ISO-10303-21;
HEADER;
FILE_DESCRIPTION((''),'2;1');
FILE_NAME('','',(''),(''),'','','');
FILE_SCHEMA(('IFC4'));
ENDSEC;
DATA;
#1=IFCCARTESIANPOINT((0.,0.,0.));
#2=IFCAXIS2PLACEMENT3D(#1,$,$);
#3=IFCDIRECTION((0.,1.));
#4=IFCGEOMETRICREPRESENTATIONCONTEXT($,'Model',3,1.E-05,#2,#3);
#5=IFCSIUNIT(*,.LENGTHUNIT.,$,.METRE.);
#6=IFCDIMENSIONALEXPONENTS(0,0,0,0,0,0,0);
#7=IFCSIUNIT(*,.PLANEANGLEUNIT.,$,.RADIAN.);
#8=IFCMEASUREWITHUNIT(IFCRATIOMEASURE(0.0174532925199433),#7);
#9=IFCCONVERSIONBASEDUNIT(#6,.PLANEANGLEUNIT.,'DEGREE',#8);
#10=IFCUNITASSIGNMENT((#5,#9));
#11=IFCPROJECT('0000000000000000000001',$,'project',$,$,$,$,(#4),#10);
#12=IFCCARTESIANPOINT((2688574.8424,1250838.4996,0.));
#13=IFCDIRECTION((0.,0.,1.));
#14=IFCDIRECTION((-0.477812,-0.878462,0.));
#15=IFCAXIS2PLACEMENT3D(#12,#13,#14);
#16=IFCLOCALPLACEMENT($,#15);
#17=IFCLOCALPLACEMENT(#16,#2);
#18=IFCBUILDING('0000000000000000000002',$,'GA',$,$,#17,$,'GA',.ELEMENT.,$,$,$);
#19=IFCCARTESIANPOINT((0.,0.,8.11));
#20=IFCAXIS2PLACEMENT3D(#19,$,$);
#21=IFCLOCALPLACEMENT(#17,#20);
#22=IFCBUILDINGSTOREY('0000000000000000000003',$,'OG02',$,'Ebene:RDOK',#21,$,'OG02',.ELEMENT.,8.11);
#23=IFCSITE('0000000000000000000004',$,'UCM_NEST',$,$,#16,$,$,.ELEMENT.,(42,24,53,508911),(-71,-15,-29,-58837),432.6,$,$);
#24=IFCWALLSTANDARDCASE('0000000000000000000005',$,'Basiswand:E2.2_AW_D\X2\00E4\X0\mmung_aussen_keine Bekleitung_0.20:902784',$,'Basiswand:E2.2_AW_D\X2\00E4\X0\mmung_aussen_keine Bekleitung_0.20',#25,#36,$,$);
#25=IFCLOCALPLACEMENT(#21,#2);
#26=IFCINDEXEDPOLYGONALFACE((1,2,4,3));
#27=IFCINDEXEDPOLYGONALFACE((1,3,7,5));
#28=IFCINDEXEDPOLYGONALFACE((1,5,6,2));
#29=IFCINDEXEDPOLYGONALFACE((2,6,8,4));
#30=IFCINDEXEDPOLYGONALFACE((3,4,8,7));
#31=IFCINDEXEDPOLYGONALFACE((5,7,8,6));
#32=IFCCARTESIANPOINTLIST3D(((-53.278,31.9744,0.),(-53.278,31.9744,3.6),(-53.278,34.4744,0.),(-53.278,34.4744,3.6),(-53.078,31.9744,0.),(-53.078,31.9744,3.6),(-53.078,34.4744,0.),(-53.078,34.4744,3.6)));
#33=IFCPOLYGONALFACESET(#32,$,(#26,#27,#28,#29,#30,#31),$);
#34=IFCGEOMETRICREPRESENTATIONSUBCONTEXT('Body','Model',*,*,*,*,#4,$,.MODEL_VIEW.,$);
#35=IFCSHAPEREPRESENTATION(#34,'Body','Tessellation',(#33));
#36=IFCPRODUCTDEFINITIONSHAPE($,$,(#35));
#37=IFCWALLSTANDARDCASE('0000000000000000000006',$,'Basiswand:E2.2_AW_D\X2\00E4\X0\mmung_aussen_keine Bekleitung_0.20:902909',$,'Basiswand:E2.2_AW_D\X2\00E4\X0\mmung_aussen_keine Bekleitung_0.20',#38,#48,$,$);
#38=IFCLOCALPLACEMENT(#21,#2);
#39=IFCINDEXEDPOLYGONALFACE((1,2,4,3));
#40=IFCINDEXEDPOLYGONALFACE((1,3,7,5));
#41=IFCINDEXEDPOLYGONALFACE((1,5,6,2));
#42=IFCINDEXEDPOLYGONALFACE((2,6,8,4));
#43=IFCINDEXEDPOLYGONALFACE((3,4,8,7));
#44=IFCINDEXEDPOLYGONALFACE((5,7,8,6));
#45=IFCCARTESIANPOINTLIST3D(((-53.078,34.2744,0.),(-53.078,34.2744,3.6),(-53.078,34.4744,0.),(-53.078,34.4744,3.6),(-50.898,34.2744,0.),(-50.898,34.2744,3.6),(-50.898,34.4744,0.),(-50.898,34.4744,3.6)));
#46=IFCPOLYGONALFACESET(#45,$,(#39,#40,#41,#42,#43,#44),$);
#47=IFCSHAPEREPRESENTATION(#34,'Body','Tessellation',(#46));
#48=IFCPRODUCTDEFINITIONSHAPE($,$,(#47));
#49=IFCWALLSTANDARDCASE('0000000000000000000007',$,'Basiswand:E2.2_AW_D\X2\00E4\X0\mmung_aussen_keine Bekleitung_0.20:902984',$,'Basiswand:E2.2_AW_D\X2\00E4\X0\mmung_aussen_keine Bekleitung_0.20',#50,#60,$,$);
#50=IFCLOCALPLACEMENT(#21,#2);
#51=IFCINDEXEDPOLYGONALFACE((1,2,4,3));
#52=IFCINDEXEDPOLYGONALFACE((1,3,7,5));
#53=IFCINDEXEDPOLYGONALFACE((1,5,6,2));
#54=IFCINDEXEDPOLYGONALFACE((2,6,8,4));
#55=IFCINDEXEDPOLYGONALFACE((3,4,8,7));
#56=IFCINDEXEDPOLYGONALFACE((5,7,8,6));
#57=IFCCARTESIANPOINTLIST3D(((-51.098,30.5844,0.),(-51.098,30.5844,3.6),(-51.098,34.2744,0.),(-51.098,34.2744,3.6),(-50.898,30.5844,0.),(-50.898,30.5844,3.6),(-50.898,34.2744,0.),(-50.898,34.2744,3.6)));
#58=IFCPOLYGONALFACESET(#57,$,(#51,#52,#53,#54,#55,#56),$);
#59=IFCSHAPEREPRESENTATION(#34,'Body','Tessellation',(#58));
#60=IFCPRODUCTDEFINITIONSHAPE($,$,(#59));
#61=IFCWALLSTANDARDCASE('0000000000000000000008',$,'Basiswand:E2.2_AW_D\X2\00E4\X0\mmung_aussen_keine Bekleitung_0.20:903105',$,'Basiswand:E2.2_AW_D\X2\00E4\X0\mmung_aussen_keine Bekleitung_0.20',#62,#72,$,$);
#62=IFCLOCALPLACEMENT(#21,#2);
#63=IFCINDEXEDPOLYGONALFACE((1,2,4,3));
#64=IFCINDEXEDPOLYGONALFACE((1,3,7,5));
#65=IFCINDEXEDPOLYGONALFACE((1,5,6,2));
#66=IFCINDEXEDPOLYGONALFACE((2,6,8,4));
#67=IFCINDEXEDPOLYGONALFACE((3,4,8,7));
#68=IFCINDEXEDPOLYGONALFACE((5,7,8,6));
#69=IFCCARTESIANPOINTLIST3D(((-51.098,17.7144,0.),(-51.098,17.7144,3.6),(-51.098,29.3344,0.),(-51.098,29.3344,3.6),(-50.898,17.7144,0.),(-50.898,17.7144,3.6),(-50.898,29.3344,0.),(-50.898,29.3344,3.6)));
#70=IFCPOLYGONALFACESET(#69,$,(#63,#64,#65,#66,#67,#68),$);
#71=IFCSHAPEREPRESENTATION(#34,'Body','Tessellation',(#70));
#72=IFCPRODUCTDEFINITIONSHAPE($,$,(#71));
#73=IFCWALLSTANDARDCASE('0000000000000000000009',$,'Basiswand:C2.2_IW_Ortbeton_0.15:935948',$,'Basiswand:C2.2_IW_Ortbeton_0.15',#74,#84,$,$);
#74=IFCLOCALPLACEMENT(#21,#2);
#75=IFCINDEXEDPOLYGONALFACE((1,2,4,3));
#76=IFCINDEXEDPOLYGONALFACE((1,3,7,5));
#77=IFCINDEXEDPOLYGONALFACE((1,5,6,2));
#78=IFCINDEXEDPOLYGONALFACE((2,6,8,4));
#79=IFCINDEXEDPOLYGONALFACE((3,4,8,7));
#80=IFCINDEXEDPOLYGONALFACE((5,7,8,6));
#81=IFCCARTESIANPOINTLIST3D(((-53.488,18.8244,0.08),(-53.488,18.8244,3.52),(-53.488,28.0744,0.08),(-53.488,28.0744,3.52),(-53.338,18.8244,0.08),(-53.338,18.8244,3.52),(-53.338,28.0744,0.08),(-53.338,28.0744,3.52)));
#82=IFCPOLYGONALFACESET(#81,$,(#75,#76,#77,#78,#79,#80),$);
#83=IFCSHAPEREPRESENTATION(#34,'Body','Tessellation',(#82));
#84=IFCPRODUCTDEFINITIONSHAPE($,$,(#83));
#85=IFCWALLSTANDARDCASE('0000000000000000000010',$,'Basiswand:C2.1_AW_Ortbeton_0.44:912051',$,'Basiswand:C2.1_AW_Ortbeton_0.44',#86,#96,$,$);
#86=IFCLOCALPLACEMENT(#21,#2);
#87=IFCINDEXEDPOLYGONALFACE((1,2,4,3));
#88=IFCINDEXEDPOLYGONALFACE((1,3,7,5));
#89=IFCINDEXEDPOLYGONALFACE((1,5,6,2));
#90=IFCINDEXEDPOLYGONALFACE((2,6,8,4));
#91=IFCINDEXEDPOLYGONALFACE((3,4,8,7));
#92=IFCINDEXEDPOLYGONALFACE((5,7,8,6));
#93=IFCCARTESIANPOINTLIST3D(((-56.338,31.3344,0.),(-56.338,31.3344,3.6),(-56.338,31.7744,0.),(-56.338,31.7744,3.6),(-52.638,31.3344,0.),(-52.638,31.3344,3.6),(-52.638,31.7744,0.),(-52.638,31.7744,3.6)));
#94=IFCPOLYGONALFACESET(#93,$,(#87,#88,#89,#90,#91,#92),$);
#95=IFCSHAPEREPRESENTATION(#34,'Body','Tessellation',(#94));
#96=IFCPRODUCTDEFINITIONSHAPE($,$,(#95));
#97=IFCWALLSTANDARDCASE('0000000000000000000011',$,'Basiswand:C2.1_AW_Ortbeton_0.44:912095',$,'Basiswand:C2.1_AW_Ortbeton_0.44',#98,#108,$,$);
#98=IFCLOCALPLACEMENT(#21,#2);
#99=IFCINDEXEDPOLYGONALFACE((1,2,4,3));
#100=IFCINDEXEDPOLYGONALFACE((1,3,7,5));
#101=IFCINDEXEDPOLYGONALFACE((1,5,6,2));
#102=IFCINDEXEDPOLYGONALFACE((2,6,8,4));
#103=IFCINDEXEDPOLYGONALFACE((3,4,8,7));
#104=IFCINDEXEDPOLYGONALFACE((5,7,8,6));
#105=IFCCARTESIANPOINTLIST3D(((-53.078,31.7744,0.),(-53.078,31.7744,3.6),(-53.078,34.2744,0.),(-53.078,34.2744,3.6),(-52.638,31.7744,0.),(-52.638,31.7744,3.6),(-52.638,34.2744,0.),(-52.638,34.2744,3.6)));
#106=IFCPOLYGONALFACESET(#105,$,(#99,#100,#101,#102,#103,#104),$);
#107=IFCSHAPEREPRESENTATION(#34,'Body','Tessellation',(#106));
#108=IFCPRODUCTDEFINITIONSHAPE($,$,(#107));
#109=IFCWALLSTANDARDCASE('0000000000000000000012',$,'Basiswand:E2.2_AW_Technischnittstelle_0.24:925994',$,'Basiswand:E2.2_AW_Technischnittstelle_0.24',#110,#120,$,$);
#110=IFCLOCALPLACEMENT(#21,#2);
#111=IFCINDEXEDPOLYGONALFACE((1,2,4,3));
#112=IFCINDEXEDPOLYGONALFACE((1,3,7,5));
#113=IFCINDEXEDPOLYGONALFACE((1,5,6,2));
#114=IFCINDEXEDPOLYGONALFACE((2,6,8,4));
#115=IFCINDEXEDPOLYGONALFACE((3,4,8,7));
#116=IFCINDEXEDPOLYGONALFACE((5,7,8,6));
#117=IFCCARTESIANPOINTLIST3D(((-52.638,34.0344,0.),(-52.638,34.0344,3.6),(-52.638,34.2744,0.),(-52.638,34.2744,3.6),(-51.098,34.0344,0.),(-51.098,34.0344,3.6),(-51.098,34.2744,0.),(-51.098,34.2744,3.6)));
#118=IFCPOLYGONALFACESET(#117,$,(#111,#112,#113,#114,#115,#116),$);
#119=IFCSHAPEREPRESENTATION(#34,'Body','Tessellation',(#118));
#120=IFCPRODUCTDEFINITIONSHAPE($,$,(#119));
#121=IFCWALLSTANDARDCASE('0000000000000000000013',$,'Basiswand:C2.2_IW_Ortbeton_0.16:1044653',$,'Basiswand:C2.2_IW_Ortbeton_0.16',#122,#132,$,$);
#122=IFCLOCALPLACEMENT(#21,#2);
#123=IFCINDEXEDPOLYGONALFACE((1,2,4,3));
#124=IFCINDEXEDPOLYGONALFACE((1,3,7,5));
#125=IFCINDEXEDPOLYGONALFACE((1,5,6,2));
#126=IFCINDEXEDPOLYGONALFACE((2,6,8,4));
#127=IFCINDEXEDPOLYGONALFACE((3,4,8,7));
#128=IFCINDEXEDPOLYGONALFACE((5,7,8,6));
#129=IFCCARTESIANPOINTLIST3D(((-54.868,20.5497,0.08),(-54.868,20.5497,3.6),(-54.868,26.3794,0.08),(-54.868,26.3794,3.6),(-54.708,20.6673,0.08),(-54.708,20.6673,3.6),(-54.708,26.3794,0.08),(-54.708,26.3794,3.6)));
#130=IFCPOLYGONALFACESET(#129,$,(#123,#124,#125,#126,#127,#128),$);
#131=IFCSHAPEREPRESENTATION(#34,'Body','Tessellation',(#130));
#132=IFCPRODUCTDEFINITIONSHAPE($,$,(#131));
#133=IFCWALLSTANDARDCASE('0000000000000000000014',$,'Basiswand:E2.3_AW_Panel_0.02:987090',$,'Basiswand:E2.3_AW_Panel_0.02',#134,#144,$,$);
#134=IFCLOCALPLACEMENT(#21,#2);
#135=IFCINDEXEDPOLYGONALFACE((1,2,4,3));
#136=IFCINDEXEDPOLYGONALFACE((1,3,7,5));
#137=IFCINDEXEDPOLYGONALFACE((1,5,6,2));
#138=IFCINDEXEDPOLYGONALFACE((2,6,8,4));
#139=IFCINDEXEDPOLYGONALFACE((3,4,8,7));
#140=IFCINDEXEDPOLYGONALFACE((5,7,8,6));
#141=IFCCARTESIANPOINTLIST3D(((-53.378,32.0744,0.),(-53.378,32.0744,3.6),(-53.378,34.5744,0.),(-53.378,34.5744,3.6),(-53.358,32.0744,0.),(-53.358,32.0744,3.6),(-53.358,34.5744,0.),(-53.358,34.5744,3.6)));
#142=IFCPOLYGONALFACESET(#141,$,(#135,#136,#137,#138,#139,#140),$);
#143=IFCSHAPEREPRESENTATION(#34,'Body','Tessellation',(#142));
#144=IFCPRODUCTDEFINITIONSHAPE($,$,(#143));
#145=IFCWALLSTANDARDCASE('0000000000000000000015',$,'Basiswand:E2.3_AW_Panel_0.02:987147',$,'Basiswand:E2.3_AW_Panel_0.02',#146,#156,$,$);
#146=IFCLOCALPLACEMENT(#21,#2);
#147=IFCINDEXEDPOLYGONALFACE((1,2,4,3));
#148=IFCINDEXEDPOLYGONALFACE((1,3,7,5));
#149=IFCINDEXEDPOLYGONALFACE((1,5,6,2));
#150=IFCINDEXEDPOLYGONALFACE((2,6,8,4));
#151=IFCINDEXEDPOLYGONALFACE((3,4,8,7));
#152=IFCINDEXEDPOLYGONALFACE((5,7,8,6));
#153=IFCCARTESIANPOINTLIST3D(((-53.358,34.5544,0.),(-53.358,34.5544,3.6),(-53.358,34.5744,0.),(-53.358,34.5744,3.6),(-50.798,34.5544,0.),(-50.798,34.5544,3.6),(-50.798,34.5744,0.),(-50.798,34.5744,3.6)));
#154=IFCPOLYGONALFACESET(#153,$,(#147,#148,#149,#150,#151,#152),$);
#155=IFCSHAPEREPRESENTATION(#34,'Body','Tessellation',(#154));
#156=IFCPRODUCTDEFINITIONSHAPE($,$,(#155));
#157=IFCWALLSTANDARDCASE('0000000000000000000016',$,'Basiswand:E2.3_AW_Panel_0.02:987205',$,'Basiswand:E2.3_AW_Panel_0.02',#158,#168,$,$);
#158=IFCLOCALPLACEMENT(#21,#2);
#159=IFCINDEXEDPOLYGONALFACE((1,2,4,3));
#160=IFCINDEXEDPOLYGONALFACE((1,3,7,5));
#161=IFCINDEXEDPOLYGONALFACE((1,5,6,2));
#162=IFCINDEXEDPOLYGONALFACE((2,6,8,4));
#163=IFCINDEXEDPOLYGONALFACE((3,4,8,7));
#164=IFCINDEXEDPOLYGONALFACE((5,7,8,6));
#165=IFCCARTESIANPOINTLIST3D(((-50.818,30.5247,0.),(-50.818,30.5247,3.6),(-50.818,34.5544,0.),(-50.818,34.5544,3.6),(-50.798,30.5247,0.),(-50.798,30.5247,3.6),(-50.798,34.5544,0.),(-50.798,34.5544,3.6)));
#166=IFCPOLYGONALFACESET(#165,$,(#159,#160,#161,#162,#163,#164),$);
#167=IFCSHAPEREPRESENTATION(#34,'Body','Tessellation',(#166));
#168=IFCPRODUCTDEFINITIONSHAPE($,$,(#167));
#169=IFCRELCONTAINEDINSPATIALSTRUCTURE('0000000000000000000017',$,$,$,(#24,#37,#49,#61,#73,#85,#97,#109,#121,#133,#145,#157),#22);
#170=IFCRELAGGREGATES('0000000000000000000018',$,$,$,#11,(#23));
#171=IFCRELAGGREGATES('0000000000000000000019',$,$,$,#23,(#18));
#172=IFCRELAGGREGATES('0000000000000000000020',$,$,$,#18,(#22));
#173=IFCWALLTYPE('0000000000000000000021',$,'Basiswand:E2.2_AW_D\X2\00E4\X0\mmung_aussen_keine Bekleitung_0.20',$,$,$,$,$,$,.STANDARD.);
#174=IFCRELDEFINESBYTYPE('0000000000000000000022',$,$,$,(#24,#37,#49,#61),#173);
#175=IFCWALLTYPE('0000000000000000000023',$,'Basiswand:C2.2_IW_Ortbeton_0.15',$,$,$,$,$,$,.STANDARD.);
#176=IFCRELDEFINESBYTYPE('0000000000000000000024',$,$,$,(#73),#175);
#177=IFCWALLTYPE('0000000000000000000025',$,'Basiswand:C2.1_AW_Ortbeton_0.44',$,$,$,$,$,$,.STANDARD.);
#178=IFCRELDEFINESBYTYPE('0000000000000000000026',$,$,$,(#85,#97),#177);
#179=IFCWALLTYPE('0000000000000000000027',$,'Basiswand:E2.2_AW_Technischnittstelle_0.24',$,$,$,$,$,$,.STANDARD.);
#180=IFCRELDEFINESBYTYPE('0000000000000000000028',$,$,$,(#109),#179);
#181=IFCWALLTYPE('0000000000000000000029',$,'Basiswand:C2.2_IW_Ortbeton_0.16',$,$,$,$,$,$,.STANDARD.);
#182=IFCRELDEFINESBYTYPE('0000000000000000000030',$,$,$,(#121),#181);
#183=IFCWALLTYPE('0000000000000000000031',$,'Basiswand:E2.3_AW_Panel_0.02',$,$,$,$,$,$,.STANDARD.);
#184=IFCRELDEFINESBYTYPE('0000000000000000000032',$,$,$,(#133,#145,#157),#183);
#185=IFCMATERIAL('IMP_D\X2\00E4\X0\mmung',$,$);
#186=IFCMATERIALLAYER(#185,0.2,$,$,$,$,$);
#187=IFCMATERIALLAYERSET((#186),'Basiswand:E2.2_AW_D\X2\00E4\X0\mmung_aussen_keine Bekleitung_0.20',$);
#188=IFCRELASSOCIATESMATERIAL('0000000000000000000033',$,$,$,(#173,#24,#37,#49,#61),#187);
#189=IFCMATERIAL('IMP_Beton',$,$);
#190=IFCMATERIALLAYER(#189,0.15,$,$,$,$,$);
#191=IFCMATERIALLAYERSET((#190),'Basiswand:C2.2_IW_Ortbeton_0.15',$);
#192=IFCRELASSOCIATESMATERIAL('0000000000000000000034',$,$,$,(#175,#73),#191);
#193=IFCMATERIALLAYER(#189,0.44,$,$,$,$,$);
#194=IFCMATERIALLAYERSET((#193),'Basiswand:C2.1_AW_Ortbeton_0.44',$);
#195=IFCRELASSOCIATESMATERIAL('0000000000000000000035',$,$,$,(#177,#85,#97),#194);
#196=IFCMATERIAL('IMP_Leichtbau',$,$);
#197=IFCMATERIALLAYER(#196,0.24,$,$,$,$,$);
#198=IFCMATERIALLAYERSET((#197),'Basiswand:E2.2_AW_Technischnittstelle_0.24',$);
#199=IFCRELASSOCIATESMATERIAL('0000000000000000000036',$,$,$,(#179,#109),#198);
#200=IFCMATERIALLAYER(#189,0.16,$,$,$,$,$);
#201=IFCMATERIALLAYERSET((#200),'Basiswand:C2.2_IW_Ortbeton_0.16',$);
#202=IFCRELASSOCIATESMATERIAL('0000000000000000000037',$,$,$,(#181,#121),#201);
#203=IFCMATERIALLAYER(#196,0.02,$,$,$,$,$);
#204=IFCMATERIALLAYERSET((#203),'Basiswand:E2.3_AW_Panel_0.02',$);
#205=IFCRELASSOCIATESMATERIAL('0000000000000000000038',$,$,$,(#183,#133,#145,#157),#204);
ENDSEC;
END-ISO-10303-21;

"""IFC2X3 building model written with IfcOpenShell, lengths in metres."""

from ifc_helpers import new_model, entity, si_unit, converted_unit, direction, frame, frame_2d, origin, place, context, subcontext, project, spatial, polyline, rectangle, outline, extrude, clip, bounded_halfspace, material, layer, layer_set, layer_usage, type_object, element, save


model = new_model("IFC2X3")

# Units and contexts
model_context = context("Model", 3, precision=1e-05, world=origin(), true_north=direction((0.0, 1.0)))
body_context = subcontext(model_context, "Body", "Model", "MODEL_VIEW")
ifc_project = project(units=[si_unit("LENGTHUNIT", "METRE"), converted_unit("PLANEANGLEUNIT", "DEGREE", entity("IfcRatioMeasure", 0.0174532925199433), si_unit("PLANEANGLEUNIT", "RADIAN"), dimensions=[0, 0, 0, 0, 0, 0, 0])], contexts=[model_context])

# Site, building, storey
site_placement = place(None, frame((2688574.8424, 1250838.4996, 0.0), z_axis=(0.0, 0.0, 1.0), x_axis=(-0.477812, -0.878462, 0.0)))
site = spatial("IfcSite", under=ifc_project, at=site_placement, Name="UCM_NEST", CompositionType="ELEMENT", RefLatitude=(42, 24, 53, 508911), RefLongitude=(-71, -15, -29, -58837), RefElevation=432.6)
building_placement = place(site_placement, origin())
building = spatial("IfcBuilding", under=site, at=building_placement, Name="GA", LongName="GA", CompositionType="ELEMENT")
storey_placement = place(building_placement, frame((0.0, 0.0, 8.11)))
storey = spatial("IfcBuildingStorey", under=building, at=storey_placement, Name="OG02", ObjectType="Ebene:RDOK", LongName="OG02", CompositionType="ELEMENT", Elevation=8.11)

# Walls
ifc_material_1 = material(Name="IMP_Dämmung")
ifc_layer_1 = layer(ifc_material_1, 0.2)
ifc_layer_set_1 = layer_set([ifc_layer_1], Name="Basiswand:E2.2_AW_Dämmung_aussen_keine Bekleitung_0.20")
ifc_layer_usage_1 = layer_usage(ifc_layer_set_1, "AXIS2", "NEGATIVE", 0.1)
wall_type_1 = type_object("IfcWallType", Name="Basiswand:E2.2_AW_Dämmung_aussen_keine Bekleitung_0.20", PredefinedType="STANDARD", material=ifc_layer_set_1)
wall_1_placement = place(storey_placement, frame((-53.178, 31.9744, 0.0), z_axis=(0.0, 0.0, 1.0), x_axis=(0.0, 1.0, 0.0)))
element("IfcWallStandardCase", 1, at=wall_1_placement, inside=storey, type_object=wall_type_1, material=ifc_layer_usage_1, Name="Basiswand:E2.2_AW_Dämmung_aussen_keine Bekleitung_0.20:902784", ObjectType="Basiswand:E2.2_AW_Dämmung_aussen_keine Bekleitung_0.20", context=body_context, shape_type="SweptSolid", body=[
    extrude(rectangle(XDim=2.5, YDim=0.2, at=frame_2d((1.25, 0.0), x_axis=(-1.0, 0.0))), origin(), (0.0, 0.0, 1.0), 3.6),
])
ifc_layer_usage_2 = layer_usage(ifc_layer_set_1, "AXIS2", "NEGATIVE", 0.1)
wall_2_placement = place(storey_placement, frame((-53.078, 34.3744, 0.0)))
element("IfcWallStandardCase", 2, at=wall_2_placement, inside=storey, type_object=wall_type_1, material=ifc_layer_usage_2, Name="Basiswand:E2.2_AW_Dämmung_aussen_keine Bekleitung_0.20:902909", ObjectType="Basiswand:E2.2_AW_Dämmung_aussen_keine Bekleitung_0.20", context=body_context, shape_type="SweptSolid", body=[
    extrude(rectangle(XDim=2.18, YDim=0.2, at=frame_2d((1.09, 0.0), x_axis=(-1.0, 0.0))), origin(), (0.0, 0.0, 1.0), 3.6),
])
ifc_layer_usage_3 = layer_usage(ifc_layer_set_1, "AXIS2", "NEGATIVE", 0.1)
wall_3_placement = place(storey_placement, frame((-50.998, 34.2744, 0.0), z_axis=(0.0, 0.0, 1.0), x_axis=(0.0, -1.0, 0.0)))
element("IfcWallStandardCase", 3, at=wall_3_placement, inside=storey, type_object=wall_type_1, material=ifc_layer_usage_3, Name="Basiswand:E2.2_AW_Dämmung_aussen_keine Bekleitung_0.20:902984", ObjectType="Basiswand:E2.2_AW_Dämmung_aussen_keine Bekleitung_0.20", context=body_context, shape_type="SweptSolid", body=[
    extrude(rectangle(XDim=3.69, YDim=0.2, at=frame_2d((1.845, 0.0), x_axis=(-1.0, 0.0))), origin(), (0.0, 0.0, 1.0), 3.6),
])
ifc_layer_usage_4 = layer_usage(ifc_layer_set_1, "AXIS2", "NEGATIVE", 0.1)
wall_4_placement = place(storey_placement, frame((-50.998, 29.3344, 0.0), z_axis=(0.0, 0.0, 1.0), x_axis=(0.0, -1.0, 0.0)))
element("IfcWallStandardCase", 4, at=wall_4_placement, inside=storey, type_object=wall_type_1, material=ifc_layer_usage_4, Name="Basiswand:E2.2_AW_Dämmung_aussen_keine Bekleitung_0.20:903105", ObjectType="Basiswand:E2.2_AW_Dämmung_aussen_keine Bekleitung_0.20", context=body_context, shape_type="SweptSolid", body=[
    extrude(rectangle(XDim=11.62, YDim=0.2, at=frame_2d((5.81, 0.0), x_axis=(-1.0, 0.0))), origin(), (0.0, 0.0, 1.0), 3.6),
])

# Shared definitions
ifc_material_2 = material(Name="IMP_Beton")
ifc_layer_2 = layer(ifc_material_2, 0.15)
ifc_layer_set_2 = layer_set([ifc_layer_2], Name="Basiswand:C2.2_IW_Ortbeton_0.15")
wall_type_2 = type_object("IfcWallType", Name="Basiswand:C2.2_IW_Ortbeton_0.15", PredefinedType="STANDARD", material=ifc_layer_set_2)

# Walls
ifc_layer_usage_5 = layer_usage(ifc_layer_set_2, "AXIS2", "NEGATIVE", 0.075)
wall_5_placement = place(storey_placement, frame((-53.413, 28.0744, 0.08), z_axis=(0.0, 0.0, 1.0), x_axis=(0.0, -1.0, 0.0)))
element("IfcWallStandardCase", 5, at=wall_5_placement, inside=storey, type_object=wall_type_2, material=ifc_layer_usage_5, Name="Basiswand:C2.2_IW_Ortbeton_0.15:935948", ObjectType="Basiswand:C2.2_IW_Ortbeton_0.15", context=body_context, shape_type="Clipping", body=[
    clip(clip(extrude(rectangle(XDim=9.25, YDim=0.15, at=frame_2d((4.625, 0.0), x_axis=(-1.0, 0.0))), origin(), (0.0, 0.0, 1.0), 3.44), bounded_halfspace(frame((0.0, -0.075, 3.44), z_axis=(0.0, 0.0, -1.0), x_axis=(0.0, -1.0, 0.0)), True, frame((0.0, -0.075, 3.44), z_axis=(0.0, 0.0, -1.0), x_axis=(0.0, -1.0, 0.0)), polyline([(0.0, 0.0), (-0.15, 0.0), (-0.15, -9.1), (-0.15, -9.25), (0.0, -9.25), (0.0, 0.0)]))), bounded_halfspace(frame((9.25, -0.075, 0.0), z_axis=(0.0, 0.0, 1.0), x_axis=(0.0, -1.0, 0.0)), True, frame((9.25, -0.075, 0.0), z_axis=(0.0, 0.0, 1.0), x_axis=(0.0, -1.0, 0.0)), polyline([(0.0, 0.0), (-0.15, 0.0), (-0.15, -0.15), (-0.15, -9.25), (0.0, -9.25), (0.0, 0.0)]))),
])
ifc_layer_3 = layer(ifc_material_2, 0.44)
ifc_layer_set_3 = layer_set([ifc_layer_3], Name="Basiswand:C2.1_AW_Ortbeton_0.44")
ifc_layer_usage_6 = layer_usage(ifc_layer_set_3, "AXIS2", "NEGATIVE", 0.22)
wall_type_3 = type_object("IfcWallType", Name="Basiswand:C2.1_AW_Ortbeton_0.44", PredefinedType="STANDARD", material=ifc_layer_set_3)
wall_6_placement = place(storey_placement, frame((-56.338, 31.5544, 0.0)))
element("IfcWallStandardCase", 6, at=wall_6_placement, inside=storey, type_object=wall_type_3, material=ifc_layer_usage_6, Name="Basiswand:C2.1_AW_Ortbeton_0.44:912051", ObjectType="Basiswand:C2.1_AW_Ortbeton_0.44", context=body_context, shape_type="SweptSolid", body=[
    extrude(rectangle(XDim=3.7, YDim=0.44, at=frame_2d((1.85, 0.0), x_axis=(-1.0, 0.0))), origin(), (0.0, 0.0, 1.0), 3.6),
])
ifc_layer_usage_7 = layer_usage(ifc_layer_set_3, "AXIS2", "NEGATIVE", 0.22)
wall_7_placement = place(storey_placement, frame((-52.858, 31.7744, 0.0), z_axis=(0.0, 0.0, 1.0), x_axis=(0.0, 1.0, 0.0)))
element("IfcWallStandardCase", 7, at=wall_7_placement, inside=storey, type_object=wall_type_3, material=ifc_layer_usage_7, Name="Basiswand:C2.1_AW_Ortbeton_0.44:912095", ObjectType="Basiswand:C2.1_AW_Ortbeton_0.44", context=body_context, shape_type="SweptSolid", body=[
    extrude(rectangle(XDim=2.5, YDim=0.44, at=frame_2d((1.25, 0.0), x_axis=(-1.0, 0.0))), origin(), (0.0, 0.0, 1.0), 3.6),
])

# Wall
ifc_material_3 = material(Name="IMP_Leichtbau")
ifc_layer_4 = layer(ifc_material_3, 0.24)
ifc_layer_set_4 = layer_set([ifc_layer_4], Name="Basiswand:E2.2_AW_Technischnittstelle_0.24")
ifc_layer_usage_8 = layer_usage(ifc_layer_set_4, "AXIS2", "NEGATIVE", 0.12)
wall_type_4 = type_object("IfcWallType", Name="Basiswand:E2.2_AW_Technischnittstelle_0.24", PredefinedType="STANDARD", material=ifc_layer_set_4)
wall_8_placement = place(storey_placement, frame((-52.638, 34.1544, 0.0)))
element("IfcWallStandardCase", 8, at=wall_8_placement, inside=storey, type_object=wall_type_4, material=ifc_layer_usage_8, Name="Basiswand:E2.2_AW_Technischnittstelle_0.24:925994", ObjectType="Basiswand:E2.2_AW_Technischnittstelle_0.24", context=body_context, shape_type="SweptSolid", body=[
    extrude(rectangle(XDim=1.54, YDim=0.24, at=frame_2d((0.77, 0.0), x_axis=(-1.0, 0.0))), origin(), (0.0, 0.0, 1.0), 3.6),
])

# Walls
ifc_layer_5 = layer(ifc_material_2, 0.16)
ifc_layer_set_5 = layer_set([ifc_layer_5], Name="Basiswand:C2.2_IW_Ortbeton_0.16")
ifc_layer_usage_9 = layer_usage(ifc_layer_set_5, "AXIS2", "NEGATIVE", 0.08)
wall_type_5 = type_object("IfcWallType", Name="Basiswand:C2.2_IW_Ortbeton_0.16", PredefinedType="STANDARD", material=ifc_layer_set_5)
wall_9_placement = place(storey_placement, frame((-54.788, 26.3794, 0.08), z_axis=(0.0, 0.0, 1.0), x_axis=(0.0, -1.0, 0.0)))
element("IfcWallStandardCase", 9, at=wall_9_placement, inside=storey, type_object=wall_type_5, material=ifc_layer_usage_9, Name="Basiswand:C2.2_IW_Ortbeton_0.16:1044653", ObjectType="Basiswand:C2.2_IW_Ortbeton_0.16", context=body_context, shape_type="Clipping", body=[
    clip(extrude(outline(polyline([(0.0, -0.08), (5.6311, -0.08), (5.8297, -0.08), (5.7121, 0.08), (0.0, 0.08), (0.0, -0.08)])), origin(), (0.0, 0.0, 1.0), 3.52), bounded_halfspace(frame((5.8297, -0.08, 0.0), z_axis=(0.0, 0.0, 1.0), x_axis=(0.0, -1.0, 0.0)), True, frame((5.8297, -0.08, 0.0), z_axis=(0.0, 0.0, 1.0), x_axis=(0.0, -1.0, 0.0)), polyline([(0.0, 0.0), (-0.16, -0.1176), (-0.16, -5.7247), (0.0, -5.7247), (0.0, 0.0)]))),
])
ifc_layer_6 = layer(ifc_material_3, 0.02)
ifc_layer_set_6 = layer_set([ifc_layer_6], Name="Basiswand:E2.3_AW_Panel_0.02")
ifc_layer_usage_10 = layer_usage(ifc_layer_set_6, "AXIS2", "NEGATIVE", 0.01)
wall_type_6 = type_object("IfcWallType", Name="Basiswand:E2.3_AW_Panel_0.02", PredefinedType="STANDARD", material=ifc_layer_set_6)
wall_10_placement = place(storey_placement, frame((-53.368, 32.0744, 0.0), z_axis=(0.0, 0.0, 1.0), x_axis=(0.0, 1.0, 0.0)))
element("IfcWallStandardCase", 10, at=wall_10_placement, inside=storey, type_object=wall_type_6, material=ifc_layer_usage_10, Name="Basiswand:E2.3_AW_Panel_0.02:987090", ObjectType="Basiswand:E2.3_AW_Panel_0.02", context=body_context, shape_type="SweptSolid", body=[
    extrude(rectangle(XDim=2.5, YDim=0.02, at=frame_2d((1.25, 0.0), x_axis=(-1.0, 0.0))), origin(), (0.0, 0.0, 1.0), 3.6),
])
ifc_layer_usage_11 = layer_usage(ifc_layer_set_6, "AXIS2", "NEGATIVE", 0.01)
wall_11_placement = place(storey_placement, frame((-53.358, 34.5644, 0.0)))
element("IfcWallStandardCase", 11, at=wall_11_placement, inside=storey, type_object=wall_type_6, material=ifc_layer_usage_11, Name="Basiswand:E2.3_AW_Panel_0.02:987147", ObjectType="Basiswand:E2.3_AW_Panel_0.02", context=body_context, shape_type="SweptSolid", body=[
    extrude(rectangle(XDim=2.56, YDim=0.02, at=frame_2d((1.28, 0.0), x_axis=(-1.0, 0.0))), origin(), (0.0, 0.0, 1.0), 3.6),
])
ifc_layer_usage_12 = layer_usage(ifc_layer_set_6, "AXIS2", "NEGATIVE", 0.01)
wall_12_placement = place(storey_placement, frame((-50.808, 34.5544, 0.0), z_axis=(0.0, 0.0, 1.0), x_axis=(0.0, -1.0, 0.0)))
element("IfcWallStandardCase", 12, at=wall_12_placement, inside=storey, type_object=wall_type_6, material=ifc_layer_usage_12, Name="Basiswand:E2.3_AW_Panel_0.02:987205", ObjectType="Basiswand:E2.3_AW_Panel_0.02", context=body_context, shape_type="SweptSolid", body=[
    extrude(rectangle(XDim=4.0298, YDim=0.02, at=frame_2d((2.0149, 0.0), x_axis=(-1.0, 0.0))), origin(), (0.0, 0.0, 1.0), 3.6),
])

save(model, "model.ifc")
